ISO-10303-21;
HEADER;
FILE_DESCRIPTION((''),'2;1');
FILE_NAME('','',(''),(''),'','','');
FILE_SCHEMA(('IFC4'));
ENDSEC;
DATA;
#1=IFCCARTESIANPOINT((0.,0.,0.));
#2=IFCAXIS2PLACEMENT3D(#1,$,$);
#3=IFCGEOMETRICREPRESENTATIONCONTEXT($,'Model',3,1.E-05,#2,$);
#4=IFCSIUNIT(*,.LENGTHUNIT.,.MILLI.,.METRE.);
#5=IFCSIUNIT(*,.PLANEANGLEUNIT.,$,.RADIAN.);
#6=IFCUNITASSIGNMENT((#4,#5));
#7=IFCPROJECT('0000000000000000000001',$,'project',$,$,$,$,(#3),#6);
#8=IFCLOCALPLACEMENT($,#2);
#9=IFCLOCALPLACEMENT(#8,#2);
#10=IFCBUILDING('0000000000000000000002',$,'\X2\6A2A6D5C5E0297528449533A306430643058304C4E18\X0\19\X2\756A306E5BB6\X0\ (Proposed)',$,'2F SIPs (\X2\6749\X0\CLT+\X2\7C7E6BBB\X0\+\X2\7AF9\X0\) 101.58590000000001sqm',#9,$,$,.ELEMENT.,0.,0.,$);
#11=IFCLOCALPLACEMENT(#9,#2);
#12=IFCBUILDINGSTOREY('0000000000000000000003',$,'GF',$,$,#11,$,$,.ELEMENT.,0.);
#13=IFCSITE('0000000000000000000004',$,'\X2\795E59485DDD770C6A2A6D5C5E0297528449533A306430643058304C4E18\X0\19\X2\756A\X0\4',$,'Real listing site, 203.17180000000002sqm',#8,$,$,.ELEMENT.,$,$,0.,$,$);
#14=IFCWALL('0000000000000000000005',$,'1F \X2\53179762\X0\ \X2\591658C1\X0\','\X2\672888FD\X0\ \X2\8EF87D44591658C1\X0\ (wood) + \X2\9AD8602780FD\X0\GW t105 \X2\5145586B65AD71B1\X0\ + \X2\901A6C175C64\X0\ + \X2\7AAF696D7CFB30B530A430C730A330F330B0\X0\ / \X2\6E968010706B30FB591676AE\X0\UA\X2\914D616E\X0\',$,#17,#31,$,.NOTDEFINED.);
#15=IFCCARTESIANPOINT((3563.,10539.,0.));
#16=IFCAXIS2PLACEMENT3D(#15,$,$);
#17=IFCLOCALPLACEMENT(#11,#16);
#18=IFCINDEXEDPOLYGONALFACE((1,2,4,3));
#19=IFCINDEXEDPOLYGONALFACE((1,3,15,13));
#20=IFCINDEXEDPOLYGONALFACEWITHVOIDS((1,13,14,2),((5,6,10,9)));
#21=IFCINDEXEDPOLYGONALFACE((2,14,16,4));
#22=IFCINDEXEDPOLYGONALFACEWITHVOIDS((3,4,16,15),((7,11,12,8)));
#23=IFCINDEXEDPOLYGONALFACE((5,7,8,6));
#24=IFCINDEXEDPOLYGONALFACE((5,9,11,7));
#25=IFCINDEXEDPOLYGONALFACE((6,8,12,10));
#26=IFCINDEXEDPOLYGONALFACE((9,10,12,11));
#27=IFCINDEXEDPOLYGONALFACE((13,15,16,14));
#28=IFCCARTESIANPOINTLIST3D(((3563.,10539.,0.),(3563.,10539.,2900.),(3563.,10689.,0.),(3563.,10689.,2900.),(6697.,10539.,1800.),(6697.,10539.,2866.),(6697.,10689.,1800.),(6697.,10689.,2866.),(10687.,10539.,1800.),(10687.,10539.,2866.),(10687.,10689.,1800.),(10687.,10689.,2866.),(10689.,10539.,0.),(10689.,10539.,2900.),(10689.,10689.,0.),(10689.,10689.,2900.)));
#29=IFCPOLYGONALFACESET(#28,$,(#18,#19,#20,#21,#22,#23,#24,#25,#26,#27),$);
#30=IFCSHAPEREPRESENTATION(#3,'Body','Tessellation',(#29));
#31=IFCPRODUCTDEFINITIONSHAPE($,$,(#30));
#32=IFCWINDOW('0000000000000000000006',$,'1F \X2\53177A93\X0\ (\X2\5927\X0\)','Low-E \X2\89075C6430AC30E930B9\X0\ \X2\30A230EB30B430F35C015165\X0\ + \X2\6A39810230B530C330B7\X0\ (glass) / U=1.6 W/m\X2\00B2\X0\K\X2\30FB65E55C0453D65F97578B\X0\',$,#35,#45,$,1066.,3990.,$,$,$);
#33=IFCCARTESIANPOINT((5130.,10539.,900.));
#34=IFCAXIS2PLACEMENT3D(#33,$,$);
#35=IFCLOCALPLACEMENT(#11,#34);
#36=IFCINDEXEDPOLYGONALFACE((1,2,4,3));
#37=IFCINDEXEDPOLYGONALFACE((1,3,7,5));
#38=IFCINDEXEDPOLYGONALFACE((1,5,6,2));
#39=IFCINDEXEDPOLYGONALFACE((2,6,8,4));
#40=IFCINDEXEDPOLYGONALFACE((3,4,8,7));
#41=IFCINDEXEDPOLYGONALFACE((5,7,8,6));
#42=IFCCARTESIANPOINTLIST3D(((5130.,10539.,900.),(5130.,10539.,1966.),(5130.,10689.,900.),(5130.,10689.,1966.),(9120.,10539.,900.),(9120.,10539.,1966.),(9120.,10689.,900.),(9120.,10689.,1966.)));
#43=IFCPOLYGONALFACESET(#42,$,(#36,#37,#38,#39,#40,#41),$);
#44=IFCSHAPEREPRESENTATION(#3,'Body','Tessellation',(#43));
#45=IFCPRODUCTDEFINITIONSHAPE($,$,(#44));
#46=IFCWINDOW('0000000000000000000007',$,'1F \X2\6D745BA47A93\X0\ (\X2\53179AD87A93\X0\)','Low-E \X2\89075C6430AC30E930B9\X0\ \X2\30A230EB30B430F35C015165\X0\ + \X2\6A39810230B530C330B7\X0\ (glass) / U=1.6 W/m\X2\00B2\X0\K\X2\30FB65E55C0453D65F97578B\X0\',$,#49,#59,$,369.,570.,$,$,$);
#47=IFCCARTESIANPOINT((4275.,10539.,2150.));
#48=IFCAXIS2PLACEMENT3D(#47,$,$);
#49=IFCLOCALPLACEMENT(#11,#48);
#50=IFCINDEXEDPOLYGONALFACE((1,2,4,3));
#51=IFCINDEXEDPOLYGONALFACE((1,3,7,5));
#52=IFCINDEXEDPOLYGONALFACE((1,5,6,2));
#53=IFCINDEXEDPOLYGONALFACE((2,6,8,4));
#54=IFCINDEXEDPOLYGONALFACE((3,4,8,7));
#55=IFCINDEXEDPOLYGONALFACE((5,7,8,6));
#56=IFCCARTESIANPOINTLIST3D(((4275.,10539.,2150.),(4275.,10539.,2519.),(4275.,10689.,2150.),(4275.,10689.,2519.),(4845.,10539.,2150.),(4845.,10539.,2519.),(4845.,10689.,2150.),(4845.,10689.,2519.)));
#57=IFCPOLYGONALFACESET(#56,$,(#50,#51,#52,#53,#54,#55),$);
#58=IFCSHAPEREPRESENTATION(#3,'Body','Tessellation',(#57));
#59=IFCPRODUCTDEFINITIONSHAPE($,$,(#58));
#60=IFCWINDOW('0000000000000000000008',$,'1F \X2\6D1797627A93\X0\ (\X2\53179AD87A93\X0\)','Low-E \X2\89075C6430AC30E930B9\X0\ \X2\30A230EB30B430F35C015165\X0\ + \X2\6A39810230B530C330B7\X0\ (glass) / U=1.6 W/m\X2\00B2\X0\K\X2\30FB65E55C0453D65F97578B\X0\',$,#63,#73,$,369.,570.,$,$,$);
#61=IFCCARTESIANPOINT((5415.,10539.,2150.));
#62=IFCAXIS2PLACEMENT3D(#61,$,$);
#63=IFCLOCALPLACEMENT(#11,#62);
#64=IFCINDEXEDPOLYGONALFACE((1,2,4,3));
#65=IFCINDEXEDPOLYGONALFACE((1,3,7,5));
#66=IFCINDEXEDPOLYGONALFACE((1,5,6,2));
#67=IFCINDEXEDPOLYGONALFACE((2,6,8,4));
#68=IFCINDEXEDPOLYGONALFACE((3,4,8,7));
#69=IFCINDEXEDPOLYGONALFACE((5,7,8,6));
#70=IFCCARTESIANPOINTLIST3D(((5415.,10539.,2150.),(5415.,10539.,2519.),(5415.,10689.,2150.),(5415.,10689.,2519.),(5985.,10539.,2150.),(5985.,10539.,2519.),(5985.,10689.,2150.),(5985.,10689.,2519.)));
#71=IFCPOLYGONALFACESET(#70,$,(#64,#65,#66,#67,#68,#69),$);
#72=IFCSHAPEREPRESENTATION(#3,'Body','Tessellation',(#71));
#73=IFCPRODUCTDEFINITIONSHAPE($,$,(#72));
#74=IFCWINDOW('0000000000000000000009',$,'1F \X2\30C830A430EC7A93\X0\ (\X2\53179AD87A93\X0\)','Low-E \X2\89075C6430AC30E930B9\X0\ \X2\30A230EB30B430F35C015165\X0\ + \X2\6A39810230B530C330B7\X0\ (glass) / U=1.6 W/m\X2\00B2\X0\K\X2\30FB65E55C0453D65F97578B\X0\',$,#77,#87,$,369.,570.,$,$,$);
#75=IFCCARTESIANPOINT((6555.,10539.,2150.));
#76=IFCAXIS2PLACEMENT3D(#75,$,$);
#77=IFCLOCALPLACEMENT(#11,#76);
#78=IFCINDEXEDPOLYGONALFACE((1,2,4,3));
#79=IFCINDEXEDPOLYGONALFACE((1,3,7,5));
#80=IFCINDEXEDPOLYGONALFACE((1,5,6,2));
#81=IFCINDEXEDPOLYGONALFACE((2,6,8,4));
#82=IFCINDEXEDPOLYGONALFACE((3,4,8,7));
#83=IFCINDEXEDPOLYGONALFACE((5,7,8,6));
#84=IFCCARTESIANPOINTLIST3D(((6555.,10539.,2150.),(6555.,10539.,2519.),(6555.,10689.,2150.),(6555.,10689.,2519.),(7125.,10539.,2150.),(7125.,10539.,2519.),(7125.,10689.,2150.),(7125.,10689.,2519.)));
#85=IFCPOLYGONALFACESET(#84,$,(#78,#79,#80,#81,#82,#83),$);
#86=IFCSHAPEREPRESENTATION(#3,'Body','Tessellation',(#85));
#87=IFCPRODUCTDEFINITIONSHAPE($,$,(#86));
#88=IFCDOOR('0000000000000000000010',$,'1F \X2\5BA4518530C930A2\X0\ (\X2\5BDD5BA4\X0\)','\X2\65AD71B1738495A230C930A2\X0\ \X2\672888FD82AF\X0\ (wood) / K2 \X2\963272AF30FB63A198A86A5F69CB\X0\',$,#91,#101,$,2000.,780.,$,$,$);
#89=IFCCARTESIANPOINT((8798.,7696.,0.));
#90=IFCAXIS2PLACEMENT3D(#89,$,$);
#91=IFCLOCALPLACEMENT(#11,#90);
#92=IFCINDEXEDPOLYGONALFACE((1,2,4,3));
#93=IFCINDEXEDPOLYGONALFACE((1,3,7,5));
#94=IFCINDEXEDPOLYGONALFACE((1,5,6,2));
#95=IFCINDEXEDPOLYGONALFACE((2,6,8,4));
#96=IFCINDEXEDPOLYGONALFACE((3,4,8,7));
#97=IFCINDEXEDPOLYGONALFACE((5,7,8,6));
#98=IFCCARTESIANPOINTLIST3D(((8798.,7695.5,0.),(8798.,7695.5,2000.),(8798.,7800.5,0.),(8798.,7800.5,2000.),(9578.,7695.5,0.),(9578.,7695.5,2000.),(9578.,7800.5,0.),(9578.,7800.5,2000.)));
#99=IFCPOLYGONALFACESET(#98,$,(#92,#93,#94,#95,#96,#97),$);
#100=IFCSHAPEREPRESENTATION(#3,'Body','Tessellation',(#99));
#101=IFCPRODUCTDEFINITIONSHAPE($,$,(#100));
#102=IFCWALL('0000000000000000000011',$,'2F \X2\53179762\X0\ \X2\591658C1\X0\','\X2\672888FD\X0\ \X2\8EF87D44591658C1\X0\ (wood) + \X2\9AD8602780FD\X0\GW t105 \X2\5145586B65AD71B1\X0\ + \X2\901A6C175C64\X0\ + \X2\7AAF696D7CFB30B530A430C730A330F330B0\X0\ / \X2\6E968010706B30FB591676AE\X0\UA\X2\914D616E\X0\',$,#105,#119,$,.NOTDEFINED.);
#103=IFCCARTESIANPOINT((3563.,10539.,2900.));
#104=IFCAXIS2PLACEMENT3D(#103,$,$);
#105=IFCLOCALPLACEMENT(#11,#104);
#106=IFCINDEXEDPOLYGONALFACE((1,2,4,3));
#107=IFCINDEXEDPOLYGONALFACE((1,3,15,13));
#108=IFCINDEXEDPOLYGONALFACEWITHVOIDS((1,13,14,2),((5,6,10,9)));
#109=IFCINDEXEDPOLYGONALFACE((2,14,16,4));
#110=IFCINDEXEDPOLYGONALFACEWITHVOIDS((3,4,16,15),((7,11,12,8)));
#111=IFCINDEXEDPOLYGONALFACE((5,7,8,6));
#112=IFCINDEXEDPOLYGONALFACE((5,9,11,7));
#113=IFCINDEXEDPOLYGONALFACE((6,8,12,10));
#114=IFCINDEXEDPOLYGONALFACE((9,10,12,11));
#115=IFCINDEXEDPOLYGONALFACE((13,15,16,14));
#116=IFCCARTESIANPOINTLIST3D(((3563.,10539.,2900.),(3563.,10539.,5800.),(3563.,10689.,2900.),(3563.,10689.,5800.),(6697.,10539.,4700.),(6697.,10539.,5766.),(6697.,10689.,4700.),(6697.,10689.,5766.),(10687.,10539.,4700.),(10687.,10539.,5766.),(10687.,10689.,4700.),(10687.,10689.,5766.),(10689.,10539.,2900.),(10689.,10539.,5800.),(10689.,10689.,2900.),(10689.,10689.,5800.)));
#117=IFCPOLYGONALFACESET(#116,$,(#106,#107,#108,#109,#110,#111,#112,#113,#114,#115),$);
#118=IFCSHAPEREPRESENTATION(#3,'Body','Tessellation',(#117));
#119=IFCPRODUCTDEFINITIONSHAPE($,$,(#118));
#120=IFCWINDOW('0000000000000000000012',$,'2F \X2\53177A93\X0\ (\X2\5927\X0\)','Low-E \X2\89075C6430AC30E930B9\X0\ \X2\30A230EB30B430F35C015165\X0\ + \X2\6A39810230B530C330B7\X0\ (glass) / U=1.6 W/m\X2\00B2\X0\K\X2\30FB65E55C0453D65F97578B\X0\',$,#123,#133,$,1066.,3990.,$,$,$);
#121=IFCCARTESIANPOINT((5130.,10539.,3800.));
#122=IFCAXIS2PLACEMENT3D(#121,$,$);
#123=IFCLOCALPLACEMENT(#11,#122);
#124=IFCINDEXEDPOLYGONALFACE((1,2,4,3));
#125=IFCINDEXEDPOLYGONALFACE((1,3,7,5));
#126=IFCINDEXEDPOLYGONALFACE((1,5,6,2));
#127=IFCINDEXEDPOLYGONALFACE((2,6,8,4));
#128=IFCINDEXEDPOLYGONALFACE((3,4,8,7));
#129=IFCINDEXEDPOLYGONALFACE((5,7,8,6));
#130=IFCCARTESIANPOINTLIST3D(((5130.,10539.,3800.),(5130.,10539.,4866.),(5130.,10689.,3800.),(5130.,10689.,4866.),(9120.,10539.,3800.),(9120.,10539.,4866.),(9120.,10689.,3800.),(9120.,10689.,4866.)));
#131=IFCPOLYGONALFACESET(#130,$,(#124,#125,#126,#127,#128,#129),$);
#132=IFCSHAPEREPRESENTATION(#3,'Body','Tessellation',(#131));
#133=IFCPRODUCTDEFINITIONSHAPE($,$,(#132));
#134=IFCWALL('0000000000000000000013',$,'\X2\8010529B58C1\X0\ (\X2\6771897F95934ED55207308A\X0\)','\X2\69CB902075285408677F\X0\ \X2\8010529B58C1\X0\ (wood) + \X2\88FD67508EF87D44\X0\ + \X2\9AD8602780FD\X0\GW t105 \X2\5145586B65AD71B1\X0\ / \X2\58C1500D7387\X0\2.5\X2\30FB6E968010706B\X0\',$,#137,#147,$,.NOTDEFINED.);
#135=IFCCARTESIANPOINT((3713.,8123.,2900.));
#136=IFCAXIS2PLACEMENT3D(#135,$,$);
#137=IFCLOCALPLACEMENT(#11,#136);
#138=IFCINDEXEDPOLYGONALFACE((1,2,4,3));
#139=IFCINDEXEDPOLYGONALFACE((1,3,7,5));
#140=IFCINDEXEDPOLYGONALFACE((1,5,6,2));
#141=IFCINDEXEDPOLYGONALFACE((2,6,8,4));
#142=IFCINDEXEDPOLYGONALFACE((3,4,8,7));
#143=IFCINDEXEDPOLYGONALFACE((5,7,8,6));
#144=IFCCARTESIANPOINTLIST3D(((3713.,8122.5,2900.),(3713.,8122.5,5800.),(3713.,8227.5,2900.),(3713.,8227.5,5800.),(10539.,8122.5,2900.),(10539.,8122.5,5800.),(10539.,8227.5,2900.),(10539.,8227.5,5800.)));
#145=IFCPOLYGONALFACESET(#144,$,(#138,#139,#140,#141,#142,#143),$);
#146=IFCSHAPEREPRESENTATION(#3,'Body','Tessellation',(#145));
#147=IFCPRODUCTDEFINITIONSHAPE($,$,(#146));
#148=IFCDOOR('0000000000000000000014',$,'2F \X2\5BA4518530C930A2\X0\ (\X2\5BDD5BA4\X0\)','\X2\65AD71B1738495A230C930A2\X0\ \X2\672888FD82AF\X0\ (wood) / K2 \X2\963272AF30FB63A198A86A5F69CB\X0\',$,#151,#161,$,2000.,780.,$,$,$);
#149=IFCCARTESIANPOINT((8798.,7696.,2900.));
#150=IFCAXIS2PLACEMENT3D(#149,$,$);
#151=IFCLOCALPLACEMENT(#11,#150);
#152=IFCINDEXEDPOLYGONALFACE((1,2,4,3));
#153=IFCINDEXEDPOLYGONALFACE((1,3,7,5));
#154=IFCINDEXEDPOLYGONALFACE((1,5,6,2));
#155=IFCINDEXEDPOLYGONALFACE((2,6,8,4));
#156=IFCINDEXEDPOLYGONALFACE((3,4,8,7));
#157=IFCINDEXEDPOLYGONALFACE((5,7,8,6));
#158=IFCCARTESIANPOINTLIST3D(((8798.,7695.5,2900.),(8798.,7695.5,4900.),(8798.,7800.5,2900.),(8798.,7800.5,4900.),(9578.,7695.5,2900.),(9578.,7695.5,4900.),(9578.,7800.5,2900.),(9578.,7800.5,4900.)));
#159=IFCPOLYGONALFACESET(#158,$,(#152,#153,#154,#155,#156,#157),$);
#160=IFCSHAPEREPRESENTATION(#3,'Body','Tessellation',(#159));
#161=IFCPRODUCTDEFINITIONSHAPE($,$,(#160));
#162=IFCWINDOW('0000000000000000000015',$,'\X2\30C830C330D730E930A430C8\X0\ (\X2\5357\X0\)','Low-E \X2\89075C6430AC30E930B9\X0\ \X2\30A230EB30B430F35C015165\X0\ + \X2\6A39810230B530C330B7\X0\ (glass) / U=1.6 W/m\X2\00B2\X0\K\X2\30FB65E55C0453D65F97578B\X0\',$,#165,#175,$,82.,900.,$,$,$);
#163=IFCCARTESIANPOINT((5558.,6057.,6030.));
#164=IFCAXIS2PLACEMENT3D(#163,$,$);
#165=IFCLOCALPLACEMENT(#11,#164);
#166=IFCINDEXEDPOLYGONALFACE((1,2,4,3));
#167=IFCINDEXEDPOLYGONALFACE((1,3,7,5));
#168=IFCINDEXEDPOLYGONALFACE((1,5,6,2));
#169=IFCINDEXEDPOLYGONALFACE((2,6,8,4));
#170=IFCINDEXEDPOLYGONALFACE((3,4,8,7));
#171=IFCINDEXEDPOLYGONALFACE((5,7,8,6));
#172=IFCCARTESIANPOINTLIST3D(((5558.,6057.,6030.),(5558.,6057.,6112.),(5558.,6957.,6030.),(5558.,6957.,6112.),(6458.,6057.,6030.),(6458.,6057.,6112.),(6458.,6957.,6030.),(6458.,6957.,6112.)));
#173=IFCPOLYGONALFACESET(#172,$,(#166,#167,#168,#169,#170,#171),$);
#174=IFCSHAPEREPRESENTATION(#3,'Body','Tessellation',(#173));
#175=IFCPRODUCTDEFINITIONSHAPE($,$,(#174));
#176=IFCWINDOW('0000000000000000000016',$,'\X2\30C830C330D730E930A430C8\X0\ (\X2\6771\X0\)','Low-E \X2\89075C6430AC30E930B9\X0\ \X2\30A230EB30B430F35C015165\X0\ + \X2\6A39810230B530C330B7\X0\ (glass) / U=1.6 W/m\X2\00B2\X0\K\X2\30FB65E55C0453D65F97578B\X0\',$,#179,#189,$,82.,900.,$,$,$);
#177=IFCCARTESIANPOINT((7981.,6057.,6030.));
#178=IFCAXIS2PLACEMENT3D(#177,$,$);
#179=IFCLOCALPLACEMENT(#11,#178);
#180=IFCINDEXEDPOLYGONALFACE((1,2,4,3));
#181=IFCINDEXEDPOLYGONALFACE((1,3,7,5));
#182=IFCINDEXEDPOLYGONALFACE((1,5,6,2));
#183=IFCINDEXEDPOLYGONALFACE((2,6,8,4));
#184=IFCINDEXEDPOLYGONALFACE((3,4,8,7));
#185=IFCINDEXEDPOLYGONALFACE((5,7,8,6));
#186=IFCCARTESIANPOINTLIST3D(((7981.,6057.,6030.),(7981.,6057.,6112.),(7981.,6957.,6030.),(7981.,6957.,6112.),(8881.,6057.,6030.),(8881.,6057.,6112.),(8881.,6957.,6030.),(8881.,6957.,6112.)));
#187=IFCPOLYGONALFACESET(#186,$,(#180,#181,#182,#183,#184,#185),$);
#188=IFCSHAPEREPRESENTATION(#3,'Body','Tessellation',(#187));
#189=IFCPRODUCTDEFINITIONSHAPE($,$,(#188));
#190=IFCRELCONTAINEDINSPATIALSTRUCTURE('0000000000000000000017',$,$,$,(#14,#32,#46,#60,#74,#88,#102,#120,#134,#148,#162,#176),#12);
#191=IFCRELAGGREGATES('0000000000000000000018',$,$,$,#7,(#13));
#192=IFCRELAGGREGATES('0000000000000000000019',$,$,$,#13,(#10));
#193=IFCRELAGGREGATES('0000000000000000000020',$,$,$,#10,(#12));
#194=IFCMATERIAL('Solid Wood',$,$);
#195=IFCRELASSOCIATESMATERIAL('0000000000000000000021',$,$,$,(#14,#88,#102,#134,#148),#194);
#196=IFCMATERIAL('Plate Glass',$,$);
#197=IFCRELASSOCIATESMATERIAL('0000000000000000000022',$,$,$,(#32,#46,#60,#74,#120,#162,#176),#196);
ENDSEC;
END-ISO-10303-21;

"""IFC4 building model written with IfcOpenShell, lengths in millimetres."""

from ifc_helpers import new_model, si_unit, frame, frame_2d, origin, place, context, project, spatial, rectangle, extrude, material, element, fill, save


model = new_model("IFC4")

# Units and contexts
model_context = context("Model", 3, precision=1e-05, world=origin())
ifc_project = project(units=[si_unit("LENGTHUNIT", "METRE", prefix="MILLI"), si_unit("PLANEANGLEUNIT", "RADIAN")], contexts=[model_context])

# Site, building, storey
site_placement = place(None, origin())
site = spatial("IfcSite", under=ifc_project, at=site_placement, Name="神奈川県横浜市青葉区つつじが丘19番4", ObjectType="Real listing site, 203.17180000000002sqm", CompositionType="ELEMENT", RefElevation=0.0)
building_placement = place(site_placement, origin())
building = spatial("IfcBuilding", under=site, at=building_placement, Name="横浜市青葉区つつじが丘19番の家 (Proposed)", ObjectType="2F SIPs (杉CLT+籾殻+竹) 101.58590000000001sqm", CompositionType="ELEMENT", ElevationOfRefHeight=0.0, ElevationOfTerrain=0.0)
storey_placement = place(building_placement, origin())
storey = spatial("IfcBuildingStorey", under=building, at=storey_placement, Name="GF", CompositionType="ELEMENT", Elevation=0.0)

# Wall, openings, windows
ifc_material_1 = material(Name="Solid Wood")
wall_1_placement = place(storey_placement, frame((3563.0, 10539.0, 0.0)))
wall_1 = element("IfcWall", 1, at=wall_1_placement, inside=storey, material=ifc_material_1, Name="1F 北面 外壁", Description="木製 軸組外壁 (wood) + 高性能GW t105 充填断熱 + 通気層 + 窯業系サイディング / 準耐火・外皮UA配慮", PredefinedType="NOTDEFINED", context=model_context, shape_type="SweptSolid", body=[
    extrude(rectangle(XDim=7126.0, YDim=150.0, at=frame_2d((3563.0, 75.0))), frame((3563.0, 10539.0, 0.0)), (0.0, 0.0, 1.0), 2900.0),
])
opening_1_placement = place(storey_placement, frame((5130.0, 10539.0, 900.0)))
opening_1 = element("IfcOpeningElement", 2, at=opening_1_placement, cuts=wall_1, PredefinedType="NOTDEFINED", context=model_context, shape_type="SweptSolid", body=[
    extrude(rectangle(XDim=3990.0, YDim=150.0, at=frame_2d((1995.0, 75.0))), frame((5130.0, 10539.0, 900.0)), (0.0, 0.0, 1.0), 1066.0),
])
opening_2_placement = place(storey_placement, frame((4275.0, 10539.0, 2150.0)))
opening_2 = element("IfcOpeningElement", 3, at=opening_2_placement, cuts=wall_1, PredefinedType="NOTDEFINED", context=model_context, shape_type="SweptSolid", body=[
    extrude(rectangle(XDim=570.0, YDim=150.0, at=frame_2d((285.0, 75.0))), frame((4275.0, 10539.0, 2150.0)), (0.0, 0.0, 1.0), 369.0),
])
opening_3_placement = place(storey_placement, frame((5415.0, 10539.0, 2150.0)))
opening_3 = element("IfcOpeningElement", 4, at=opening_3_placement, cuts=wall_1, PredefinedType="NOTDEFINED", context=model_context, shape_type="SweptSolid", body=[
    extrude(rectangle(XDim=570.0, YDim=150.0, at=frame_2d((285.0, 75.0))), frame((5415.0, 10539.0, 2150.0)), (0.0, 0.0, 1.0), 369.0),
])
opening_4_placement = place(storey_placement, frame((6555.0, 10539.0, 2150.0)))
opening_4 = element("IfcOpeningElement", 5, at=opening_4_placement, cuts=wall_1, PredefinedType="NOTDEFINED", context=model_context, shape_type="SweptSolid", body=[
    extrude(rectangle(XDim=570.0, YDim=150.0, at=frame_2d((285.0, 75.0))), frame((6555.0, 10539.0, 2150.0)), (0.0, 0.0, 1.0), 369.0),
])
ifc_material_2 = material(Name="Plate Glass")
window_1_placement = place(storey_placement, frame((5130.0, 10539.0, 900.0)))
window_1 = element("IfcWindow", 6, at=window_1_placement, inside=storey, material=ifc_material_2, Name="1F 北窓 (大)", Description="Low-E 複層ガラス アルゴン封入 + 樹脂サッシ (glass) / U=1.6 W/m²K・日射取得型", OverallHeight=1066.0, OverallWidth=3990.0, context=model_context, shape_type="SweptSolid", body=[
    extrude(rectangle(XDim=3990.0, YDim=150.0, at=frame_2d((1995.0, 75.0))), frame((5130.0, 10539.0, 900.0)), (0.0, 0.0, 1.0), 1066.0),
])
fill(opening_1, window_1)
window_2_placement = place(storey_placement, frame((4275.0, 10539.0, 2150.0)))
window_2 = element("IfcWindow", 7, at=window_2_placement, inside=storey, material=ifc_material_2, Name="1F 浴室窓 (北高窓)", Description="Low-E 複層ガラス アルゴン封入 + 樹脂サッシ (glass) / U=1.6 W/m²K・日射取得型", OverallHeight=369.0, OverallWidth=570.0, context=model_context, shape_type="SweptSolid", body=[
    extrude(rectangle(XDim=570.0, YDim=150.0, at=frame_2d((285.0, 75.0))), frame((4275.0, 10539.0, 2150.0)), (0.0, 0.0, 1.0), 369.0),
])
fill(opening_2, window_2)
window_3_placement = place(storey_placement, frame((5415.0, 10539.0, 2150.0)))
window_3 = element("IfcWindow", 8, at=window_3_placement, inside=storey, material=ifc_material_2, Name="1F 洗面窓 (北高窓)", Description="Low-E 複層ガラス アルゴン封入 + 樹脂サッシ (glass) / U=1.6 W/m²K・日射取得型", OverallHeight=369.0, OverallWidth=570.0, context=model_context, shape_type="SweptSolid", body=[
    extrude(rectangle(XDim=570.0, YDim=150.0, at=frame_2d((285.0, 75.0))), frame((5415.0, 10539.0, 2150.0)), (0.0, 0.0, 1.0), 369.0),
])
fill(opening_3, window_3)
window_4_placement = place(storey_placement, frame((6555.0, 10539.0, 2150.0)))
window_4 = element("IfcWindow", 9, at=window_4_placement, inside=storey, material=ifc_material_2, Name="1F トイレ窓 (北高窓)", Description="Low-E 複層ガラス アルゴン封入 + 樹脂サッシ (glass) / U=1.6 W/m²K・日射取得型", OverallHeight=369.0, OverallWidth=570.0, context=model_context, shape_type="SweptSolid", body=[
    extrude(rectangle(XDim=570.0, YDim=150.0, at=frame_2d((285.0, 75.0))), frame((6555.0, 10539.0, 2150.0)), (0.0, 0.0, 1.0), 369.0),
])
fill(opening_4, window_4)

# Door
door_1_placement = place(storey_placement, frame((8798.0, 7696.0, 0.0)))
element("IfcDoor", 10, at=door_1_placement, inside=storey, material=ifc_material_1, Name="1F 室内ドア (寝室)", Description="断熱玄関ドア 木製芯 (wood) / K2 防犯・採風機構", OverallHeight=2000.0, OverallWidth=780.0, context=model_context, shape_type="SweptSolid", body=[
    extrude(rectangle(XDim=780.0, YDim=105.0, at=frame_2d((390.0, 52.0))), frame((8798.0, 7696.0, 0.0)), (0.0, 0.0, 1.0), 2000.0),
])

# Wall, opening, window
wall_2_placement = place(storey_placement, frame((3563.0, 10539.0, 2900.0)))
wall_2 = element("IfcWall", 11, at=wall_2_placement, inside=storey, material=ifc_material_1, Name="2F 北面 外壁", Description="木製 軸組外壁 (wood) + 高性能GW t105 充填断熱 + 通気層 + 窯業系サイディング / 準耐火・外皮UA配慮", PredefinedType="NOTDEFINED", context=model_context, shape_type="SweptSolid", body=[
    extrude(rectangle(XDim=7126.0, YDim=150.0, at=frame_2d((3563.0, 75.0))), frame((3563.0, 10539.0, 2900.0)), (0.0, 0.0, 1.0), 2900.0),
])
opening_5_placement = place(storey_placement, frame((5130.0, 10539.0, 3800.0)))
opening_5 = element("IfcOpeningElement", 12, at=opening_5_placement, cuts=wall_2, PredefinedType="NOTDEFINED", context=model_context, shape_type="SweptSolid", body=[
    extrude(rectangle(XDim=3990.0, YDim=150.0, at=frame_2d((1995.0, 75.0))), frame((5130.0, 10539.0, 3800.0)), (0.0, 0.0, 1.0), 1066.0),
])
window_5_placement = place(storey_placement, frame((5130.0, 10539.0, 3800.0)))
window_5 = element("IfcWindow", 13, at=window_5_placement, inside=storey, material=ifc_material_2, Name="2F 北窓 (大)", Description="Low-E 複層ガラス アルゴン封入 + 樹脂サッシ (glass) / U=1.6 W/m²K・日射取得型", OverallHeight=1066.0, OverallWidth=3990.0, context=model_context, shape_type="SweptSolid", body=[
    extrude(rectangle(XDim=3990.0, YDim=150.0, at=frame_2d((1995.0, 75.0))), frame((5130.0, 10539.0, 3800.0)), (0.0, 0.0, 1.0), 1066.0),
])
fill(opening_5, window_5)

# Wall
wall_3_placement = place(storey_placement, frame((3713.0, 8123.0, 2900.0)))
element("IfcWall", 14, at=wall_3_placement, inside=storey, material=ifc_material_1, Name="耐力壁 (東西間仕切り)", Description="構造用合板 耐力壁 (wood) + 製材軸組 + 高性能GW t105 充填断熱 / 壁倍率2.5・準耐火", PredefinedType="NOTDEFINED", context=model_context, shape_type="SweptSolid", body=[
    extrude(rectangle(XDim=6826.0, YDim=105.0, at=frame_2d((3413.0, 52.0))), frame((3713.0, 8123.0, 2900.0)), (0.0, 0.0, 1.0), 2900.0),
])

# Door
door_2_placement = place(storey_placement, frame((8798.0, 7696.0, 2900.0)))
element("IfcDoor", 15, at=door_2_placement, inside=storey, material=ifc_material_1, Name="2F 室内ドア (寝室)", Description="断熱玄関ドア 木製芯 (wood) / K2 防犯・採風機構", OverallHeight=2000.0, OverallWidth=780.0, context=model_context, shape_type="SweptSolid", body=[
    extrude(rectangle(XDim=780.0, YDim=105.0, at=frame_2d((390.0, 52.0))), frame((8798.0, 7696.0, 2900.0)), (0.0, 0.0, 1.0), 2000.0),
])

# Windows
window_6_placement = place(storey_placement, frame((5558.0, 6057.0, 6030.0)))
element("IfcWindow", 16, at=window_6_placement, inside=storey, material=ifc_material_2, Name="トップライト (南)", Description="Low-E 複層ガラス アルゴン封入 + 樹脂サッシ (glass) / U=1.6 W/m²K・日射取得型", OverallHeight=82.0, OverallWidth=900.0, context=model_context, shape_type="SweptSolid", body=[
    extrude(rectangle(XDim=900.0, YDim=900.0, at=frame_2d((450.0, 450.0))), frame((5558.0, 6057.0, 6030.0)), (0.0, 0.0, 1.0), 82.0),
])
window_7_placement = place(storey_placement, frame((7981.0, 6057.0, 6030.0)))
element("IfcWindow", 17, at=window_7_placement, inside=storey, material=ifc_material_2, Name="トップライト (東)", Description="Low-E 複層ガラス アルゴン封入 + 樹脂サッシ (glass) / U=1.6 W/m²K・日射取得型", OverallHeight=82.0, OverallWidth=900.0, context=model_context, shape_type="SweptSolid", body=[
    extrude(rectangle(XDim=900.0, YDim=900.0, at=frame_2d((450.0, 450.0))), frame((7981.0, 6057.0, 6030.0)), (0.0, 0.0, 1.0), 82.0),
])

save(model, "model.ifc")
